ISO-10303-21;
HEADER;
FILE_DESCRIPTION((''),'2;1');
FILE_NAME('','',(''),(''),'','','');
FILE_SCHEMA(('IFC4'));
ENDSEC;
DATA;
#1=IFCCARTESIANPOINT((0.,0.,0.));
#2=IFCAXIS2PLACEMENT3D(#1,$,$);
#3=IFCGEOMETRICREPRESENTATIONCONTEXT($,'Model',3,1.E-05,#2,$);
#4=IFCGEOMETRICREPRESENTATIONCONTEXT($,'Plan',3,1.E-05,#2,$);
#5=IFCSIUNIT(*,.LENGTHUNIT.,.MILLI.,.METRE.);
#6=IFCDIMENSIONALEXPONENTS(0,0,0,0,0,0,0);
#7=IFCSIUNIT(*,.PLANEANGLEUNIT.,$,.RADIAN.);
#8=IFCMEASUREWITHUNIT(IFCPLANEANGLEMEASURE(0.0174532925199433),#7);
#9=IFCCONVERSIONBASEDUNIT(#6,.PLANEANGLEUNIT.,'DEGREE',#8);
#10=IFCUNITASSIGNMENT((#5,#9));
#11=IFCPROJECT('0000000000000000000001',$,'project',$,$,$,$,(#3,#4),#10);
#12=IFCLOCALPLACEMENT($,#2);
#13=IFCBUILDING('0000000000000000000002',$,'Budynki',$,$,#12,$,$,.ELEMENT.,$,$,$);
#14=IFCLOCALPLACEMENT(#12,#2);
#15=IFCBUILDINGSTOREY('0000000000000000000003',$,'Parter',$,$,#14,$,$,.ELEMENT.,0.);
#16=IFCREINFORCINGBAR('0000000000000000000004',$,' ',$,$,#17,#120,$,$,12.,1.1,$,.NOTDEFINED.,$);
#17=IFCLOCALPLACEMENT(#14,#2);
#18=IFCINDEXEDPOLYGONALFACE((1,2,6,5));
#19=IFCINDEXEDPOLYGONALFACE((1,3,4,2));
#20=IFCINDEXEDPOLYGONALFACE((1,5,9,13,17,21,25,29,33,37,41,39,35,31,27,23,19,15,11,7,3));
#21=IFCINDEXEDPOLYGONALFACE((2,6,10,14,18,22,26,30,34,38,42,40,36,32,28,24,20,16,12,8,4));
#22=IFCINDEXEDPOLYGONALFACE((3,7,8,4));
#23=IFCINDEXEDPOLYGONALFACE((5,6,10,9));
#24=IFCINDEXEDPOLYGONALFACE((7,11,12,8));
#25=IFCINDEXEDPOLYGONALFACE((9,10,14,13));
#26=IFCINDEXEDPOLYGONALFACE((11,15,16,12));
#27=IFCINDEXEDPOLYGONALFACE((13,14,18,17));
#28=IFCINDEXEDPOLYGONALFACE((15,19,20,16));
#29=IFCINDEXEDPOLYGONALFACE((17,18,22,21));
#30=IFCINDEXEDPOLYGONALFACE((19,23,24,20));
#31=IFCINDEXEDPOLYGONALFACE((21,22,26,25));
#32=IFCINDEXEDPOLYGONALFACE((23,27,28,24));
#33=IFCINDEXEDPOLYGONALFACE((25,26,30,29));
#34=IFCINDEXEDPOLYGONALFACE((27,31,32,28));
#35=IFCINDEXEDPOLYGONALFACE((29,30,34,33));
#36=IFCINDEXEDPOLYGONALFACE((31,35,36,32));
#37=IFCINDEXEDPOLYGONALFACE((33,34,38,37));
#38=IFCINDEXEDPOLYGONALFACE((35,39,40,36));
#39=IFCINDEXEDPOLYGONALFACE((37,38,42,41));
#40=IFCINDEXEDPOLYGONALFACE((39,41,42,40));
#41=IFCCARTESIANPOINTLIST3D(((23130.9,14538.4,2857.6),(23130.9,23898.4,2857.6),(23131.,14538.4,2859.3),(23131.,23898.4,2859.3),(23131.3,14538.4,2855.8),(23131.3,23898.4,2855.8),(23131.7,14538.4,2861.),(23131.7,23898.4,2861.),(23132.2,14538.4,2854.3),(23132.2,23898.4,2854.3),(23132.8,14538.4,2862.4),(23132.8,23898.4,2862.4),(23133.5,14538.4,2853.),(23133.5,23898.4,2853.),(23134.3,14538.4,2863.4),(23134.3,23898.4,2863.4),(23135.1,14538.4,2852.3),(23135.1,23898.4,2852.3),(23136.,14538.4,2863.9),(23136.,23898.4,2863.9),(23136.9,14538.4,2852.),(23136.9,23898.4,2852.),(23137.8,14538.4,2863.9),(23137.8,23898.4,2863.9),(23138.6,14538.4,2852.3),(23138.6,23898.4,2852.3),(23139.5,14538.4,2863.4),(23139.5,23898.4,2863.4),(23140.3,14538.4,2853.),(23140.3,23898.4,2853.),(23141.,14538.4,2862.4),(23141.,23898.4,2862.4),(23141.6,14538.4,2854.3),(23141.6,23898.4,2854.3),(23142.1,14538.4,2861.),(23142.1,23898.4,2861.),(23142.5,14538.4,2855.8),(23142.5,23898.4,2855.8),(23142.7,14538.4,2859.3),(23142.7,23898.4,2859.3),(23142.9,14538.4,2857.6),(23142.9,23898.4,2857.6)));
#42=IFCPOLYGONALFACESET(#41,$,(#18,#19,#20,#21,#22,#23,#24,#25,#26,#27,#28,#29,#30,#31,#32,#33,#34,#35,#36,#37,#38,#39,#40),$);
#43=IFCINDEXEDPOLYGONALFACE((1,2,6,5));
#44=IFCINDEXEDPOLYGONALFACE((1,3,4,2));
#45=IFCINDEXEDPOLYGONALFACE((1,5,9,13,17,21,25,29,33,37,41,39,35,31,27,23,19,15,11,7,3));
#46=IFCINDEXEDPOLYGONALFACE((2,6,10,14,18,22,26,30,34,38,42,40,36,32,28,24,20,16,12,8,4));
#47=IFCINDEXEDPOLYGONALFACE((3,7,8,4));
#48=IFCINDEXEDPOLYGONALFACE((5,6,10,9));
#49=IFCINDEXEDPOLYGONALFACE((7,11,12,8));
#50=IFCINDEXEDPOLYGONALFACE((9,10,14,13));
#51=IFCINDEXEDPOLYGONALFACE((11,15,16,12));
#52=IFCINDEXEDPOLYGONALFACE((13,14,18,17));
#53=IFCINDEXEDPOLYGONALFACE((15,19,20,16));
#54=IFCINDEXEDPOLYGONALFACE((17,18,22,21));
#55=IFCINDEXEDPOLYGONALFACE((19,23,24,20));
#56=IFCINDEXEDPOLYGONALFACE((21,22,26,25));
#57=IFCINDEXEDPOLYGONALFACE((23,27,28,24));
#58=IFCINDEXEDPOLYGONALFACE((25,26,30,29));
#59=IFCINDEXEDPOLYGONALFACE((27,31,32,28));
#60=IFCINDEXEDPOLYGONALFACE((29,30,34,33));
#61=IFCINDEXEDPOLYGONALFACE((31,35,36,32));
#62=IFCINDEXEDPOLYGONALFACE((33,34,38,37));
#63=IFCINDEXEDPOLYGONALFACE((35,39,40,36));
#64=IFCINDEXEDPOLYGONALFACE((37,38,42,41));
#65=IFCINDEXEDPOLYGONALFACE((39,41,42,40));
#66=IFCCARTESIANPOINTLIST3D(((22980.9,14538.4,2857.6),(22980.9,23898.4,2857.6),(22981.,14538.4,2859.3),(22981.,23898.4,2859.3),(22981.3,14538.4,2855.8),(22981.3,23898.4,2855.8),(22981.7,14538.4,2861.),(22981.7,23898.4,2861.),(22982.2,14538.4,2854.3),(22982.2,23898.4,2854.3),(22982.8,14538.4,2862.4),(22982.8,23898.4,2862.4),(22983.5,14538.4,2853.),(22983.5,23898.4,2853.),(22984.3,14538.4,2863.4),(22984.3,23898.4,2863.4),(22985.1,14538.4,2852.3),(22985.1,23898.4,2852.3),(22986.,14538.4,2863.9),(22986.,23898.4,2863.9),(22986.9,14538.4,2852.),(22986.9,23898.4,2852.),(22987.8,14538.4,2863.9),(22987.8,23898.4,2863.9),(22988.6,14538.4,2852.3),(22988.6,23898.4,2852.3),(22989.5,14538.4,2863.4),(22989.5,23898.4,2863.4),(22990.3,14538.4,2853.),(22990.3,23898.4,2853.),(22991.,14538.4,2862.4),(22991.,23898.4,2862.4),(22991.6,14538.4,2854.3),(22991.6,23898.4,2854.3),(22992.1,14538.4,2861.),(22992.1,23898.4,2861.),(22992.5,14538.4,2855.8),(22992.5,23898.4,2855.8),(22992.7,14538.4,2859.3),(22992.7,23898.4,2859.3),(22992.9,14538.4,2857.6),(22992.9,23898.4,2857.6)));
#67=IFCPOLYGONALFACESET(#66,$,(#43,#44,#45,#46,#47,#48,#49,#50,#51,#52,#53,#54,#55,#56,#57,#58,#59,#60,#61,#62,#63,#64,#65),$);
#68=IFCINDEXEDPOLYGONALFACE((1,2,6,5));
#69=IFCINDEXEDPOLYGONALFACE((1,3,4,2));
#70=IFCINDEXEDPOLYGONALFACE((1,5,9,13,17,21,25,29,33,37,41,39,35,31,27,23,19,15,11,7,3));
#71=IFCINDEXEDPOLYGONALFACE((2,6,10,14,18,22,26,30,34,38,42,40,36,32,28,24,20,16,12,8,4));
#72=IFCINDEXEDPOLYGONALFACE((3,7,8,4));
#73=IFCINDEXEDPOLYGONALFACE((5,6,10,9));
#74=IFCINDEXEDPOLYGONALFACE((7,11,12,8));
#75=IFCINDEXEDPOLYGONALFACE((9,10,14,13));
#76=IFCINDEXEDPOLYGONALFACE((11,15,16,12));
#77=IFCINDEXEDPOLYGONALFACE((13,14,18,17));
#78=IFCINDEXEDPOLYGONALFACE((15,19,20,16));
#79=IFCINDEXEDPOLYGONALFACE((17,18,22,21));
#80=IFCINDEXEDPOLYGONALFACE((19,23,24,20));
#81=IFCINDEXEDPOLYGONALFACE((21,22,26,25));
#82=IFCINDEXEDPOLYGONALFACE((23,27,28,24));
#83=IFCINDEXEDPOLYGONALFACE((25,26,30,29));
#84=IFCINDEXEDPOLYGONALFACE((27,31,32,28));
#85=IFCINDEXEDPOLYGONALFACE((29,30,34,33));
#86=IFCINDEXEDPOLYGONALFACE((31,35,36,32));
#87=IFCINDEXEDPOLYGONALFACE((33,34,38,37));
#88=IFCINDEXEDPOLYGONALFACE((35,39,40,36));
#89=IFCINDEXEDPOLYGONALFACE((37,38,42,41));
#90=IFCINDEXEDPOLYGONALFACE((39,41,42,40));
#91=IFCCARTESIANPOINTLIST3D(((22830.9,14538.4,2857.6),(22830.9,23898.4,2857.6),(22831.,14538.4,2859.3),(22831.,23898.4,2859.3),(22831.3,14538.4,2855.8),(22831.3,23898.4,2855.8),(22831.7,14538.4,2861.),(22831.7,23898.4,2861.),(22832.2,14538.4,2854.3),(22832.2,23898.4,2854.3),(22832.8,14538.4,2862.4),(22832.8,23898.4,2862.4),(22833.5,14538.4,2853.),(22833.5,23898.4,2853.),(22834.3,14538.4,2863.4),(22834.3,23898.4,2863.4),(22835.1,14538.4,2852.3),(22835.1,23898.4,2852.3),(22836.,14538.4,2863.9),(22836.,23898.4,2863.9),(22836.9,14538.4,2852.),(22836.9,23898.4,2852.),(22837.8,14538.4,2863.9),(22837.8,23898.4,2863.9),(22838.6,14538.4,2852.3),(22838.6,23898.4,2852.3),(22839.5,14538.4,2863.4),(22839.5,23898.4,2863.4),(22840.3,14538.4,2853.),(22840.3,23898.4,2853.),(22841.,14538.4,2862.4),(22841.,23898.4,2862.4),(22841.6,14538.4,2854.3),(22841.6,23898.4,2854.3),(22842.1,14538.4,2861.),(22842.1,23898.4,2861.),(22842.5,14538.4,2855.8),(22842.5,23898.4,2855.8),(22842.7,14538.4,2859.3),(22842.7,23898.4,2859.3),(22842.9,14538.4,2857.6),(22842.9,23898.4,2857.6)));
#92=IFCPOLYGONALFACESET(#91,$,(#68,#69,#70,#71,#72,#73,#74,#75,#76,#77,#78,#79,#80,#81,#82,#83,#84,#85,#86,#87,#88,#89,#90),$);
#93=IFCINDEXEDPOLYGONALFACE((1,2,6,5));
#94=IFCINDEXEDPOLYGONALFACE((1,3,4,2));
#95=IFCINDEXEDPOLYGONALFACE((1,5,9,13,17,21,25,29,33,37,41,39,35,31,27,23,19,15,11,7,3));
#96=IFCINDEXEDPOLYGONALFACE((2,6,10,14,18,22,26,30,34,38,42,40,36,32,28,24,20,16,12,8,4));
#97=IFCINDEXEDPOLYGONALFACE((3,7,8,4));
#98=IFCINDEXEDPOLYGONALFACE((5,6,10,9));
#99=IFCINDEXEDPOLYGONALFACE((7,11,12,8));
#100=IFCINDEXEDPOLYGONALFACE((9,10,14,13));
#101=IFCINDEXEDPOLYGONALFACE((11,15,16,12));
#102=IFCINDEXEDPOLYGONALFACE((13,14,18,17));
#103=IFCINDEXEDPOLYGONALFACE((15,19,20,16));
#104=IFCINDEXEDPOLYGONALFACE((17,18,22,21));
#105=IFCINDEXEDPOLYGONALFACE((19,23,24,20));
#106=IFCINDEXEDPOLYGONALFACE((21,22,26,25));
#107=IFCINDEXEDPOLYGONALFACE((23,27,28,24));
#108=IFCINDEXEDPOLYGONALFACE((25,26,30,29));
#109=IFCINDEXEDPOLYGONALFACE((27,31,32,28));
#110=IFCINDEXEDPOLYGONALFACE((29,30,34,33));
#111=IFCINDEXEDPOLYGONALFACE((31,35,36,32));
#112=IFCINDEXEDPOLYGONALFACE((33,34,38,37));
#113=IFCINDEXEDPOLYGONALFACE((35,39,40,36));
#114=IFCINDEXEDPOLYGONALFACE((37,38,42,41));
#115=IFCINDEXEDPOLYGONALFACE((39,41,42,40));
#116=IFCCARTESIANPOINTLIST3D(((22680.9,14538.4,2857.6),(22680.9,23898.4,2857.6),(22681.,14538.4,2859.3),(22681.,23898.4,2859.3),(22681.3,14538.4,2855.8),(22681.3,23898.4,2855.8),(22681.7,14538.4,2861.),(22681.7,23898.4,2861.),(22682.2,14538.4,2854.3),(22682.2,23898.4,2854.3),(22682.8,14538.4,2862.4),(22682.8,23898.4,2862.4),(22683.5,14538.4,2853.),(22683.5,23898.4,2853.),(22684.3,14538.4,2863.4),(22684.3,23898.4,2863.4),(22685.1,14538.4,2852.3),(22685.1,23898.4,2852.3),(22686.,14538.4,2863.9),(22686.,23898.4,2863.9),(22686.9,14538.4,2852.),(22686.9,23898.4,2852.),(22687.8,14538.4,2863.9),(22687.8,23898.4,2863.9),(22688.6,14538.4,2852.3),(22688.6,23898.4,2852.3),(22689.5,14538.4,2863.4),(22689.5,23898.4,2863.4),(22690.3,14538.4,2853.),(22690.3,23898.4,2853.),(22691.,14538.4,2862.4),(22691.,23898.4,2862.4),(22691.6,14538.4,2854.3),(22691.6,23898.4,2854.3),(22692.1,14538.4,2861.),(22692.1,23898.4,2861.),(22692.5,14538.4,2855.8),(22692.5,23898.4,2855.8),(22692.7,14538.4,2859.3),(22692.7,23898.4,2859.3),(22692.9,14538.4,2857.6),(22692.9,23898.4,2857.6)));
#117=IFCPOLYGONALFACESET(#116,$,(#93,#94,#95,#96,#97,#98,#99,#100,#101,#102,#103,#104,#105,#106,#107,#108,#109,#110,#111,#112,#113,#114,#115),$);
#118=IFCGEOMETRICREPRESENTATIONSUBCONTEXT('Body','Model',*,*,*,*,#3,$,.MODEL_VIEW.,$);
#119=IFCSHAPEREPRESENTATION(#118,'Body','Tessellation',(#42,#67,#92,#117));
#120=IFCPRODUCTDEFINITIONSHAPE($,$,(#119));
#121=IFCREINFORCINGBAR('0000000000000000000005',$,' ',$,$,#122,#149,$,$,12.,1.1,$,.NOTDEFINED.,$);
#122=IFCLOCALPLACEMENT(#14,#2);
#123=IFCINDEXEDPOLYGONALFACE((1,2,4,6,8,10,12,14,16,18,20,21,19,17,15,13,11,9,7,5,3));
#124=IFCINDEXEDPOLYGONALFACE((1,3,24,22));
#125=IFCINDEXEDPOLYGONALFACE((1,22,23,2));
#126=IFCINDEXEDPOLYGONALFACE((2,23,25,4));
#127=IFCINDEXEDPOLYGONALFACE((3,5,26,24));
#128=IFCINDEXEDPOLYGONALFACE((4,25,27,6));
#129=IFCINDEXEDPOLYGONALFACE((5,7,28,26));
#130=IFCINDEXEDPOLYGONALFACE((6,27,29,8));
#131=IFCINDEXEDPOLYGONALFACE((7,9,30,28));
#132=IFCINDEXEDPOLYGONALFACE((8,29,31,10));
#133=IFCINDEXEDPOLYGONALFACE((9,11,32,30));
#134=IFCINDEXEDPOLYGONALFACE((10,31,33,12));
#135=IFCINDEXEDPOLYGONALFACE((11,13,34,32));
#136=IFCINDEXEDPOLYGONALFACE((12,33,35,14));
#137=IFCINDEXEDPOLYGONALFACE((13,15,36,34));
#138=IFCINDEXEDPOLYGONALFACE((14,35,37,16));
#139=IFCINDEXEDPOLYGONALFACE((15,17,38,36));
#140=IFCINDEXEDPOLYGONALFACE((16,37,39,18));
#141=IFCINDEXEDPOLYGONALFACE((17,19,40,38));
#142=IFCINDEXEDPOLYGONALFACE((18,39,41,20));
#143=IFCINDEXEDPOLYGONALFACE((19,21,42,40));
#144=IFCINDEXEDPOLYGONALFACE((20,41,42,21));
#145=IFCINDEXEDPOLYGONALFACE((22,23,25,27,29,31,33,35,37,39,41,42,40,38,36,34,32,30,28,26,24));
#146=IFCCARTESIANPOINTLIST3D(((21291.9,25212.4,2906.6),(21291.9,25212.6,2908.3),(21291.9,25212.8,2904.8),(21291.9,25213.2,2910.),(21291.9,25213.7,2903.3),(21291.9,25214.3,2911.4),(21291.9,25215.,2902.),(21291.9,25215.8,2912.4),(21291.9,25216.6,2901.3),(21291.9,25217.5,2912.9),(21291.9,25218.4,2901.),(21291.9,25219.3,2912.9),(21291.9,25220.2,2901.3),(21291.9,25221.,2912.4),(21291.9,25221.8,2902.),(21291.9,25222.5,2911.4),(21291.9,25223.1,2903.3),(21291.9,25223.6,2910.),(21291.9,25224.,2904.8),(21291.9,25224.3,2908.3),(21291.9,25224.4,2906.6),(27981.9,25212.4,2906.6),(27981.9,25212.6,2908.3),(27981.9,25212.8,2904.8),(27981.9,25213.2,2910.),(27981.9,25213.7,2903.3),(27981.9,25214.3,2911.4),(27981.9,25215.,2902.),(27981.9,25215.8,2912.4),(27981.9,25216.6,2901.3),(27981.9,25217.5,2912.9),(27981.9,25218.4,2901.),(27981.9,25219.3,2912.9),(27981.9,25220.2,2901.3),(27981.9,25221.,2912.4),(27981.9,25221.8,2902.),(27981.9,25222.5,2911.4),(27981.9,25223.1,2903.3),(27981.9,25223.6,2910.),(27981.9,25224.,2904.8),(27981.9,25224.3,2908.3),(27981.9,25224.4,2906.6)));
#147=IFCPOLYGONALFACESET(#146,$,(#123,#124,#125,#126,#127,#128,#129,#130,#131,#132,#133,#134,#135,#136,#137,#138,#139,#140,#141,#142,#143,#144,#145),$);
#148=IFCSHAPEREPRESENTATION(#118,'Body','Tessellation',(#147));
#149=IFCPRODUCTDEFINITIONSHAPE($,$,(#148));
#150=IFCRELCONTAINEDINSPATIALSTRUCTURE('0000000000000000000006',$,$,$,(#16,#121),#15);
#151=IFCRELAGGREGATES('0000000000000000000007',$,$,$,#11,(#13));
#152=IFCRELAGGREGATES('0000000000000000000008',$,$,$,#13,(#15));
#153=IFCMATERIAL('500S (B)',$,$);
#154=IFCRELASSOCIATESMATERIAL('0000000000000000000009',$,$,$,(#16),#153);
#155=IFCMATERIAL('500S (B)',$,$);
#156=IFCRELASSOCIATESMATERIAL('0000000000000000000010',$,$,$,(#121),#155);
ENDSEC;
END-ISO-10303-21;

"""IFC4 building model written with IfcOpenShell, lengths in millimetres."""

from ifc_helpers import new_model, entity, si_unit, converted_unit, frame, origin, place, context, subcontext, project, spatial, material, element, save


model = new_model("IFC4")

# Units and contexts
model_context = context("Model", 3, precision=1e-05, world=origin())
plan_context = context("Plan", 3, precision=1e-05, world=origin())
body_context = subcontext(model_context, "Body", "Model", "MODEL_VIEW")
ifc_project = project(units=[si_unit("LENGTHUNIT", "METRE", prefix="MILLI"), converted_unit("PLANEANGLEUNIT", "DEGREE", entity("IfcPlaneAngleMeasure", 0.0174532925199433), si_unit("PLANEANGLEUNIT", "RADIAN"), dimensions=[0, 0, 0, 0, 0, 0, 0])], contexts=[model_context, plan_context])

# Building, storey
building_placement = place(None, origin())
building = spatial("IfcBuilding", under=ifc_project, at=building_placement, Name="Budynki", CompositionType="ELEMENT")
storey_placement = place(building_placement, origin())
storey = spatial("IfcBuildingStorey", under=building, at=storey_placement, Name="Parter", CompositionType="ELEMENT", Elevation=0.0)

# Reinforcing bars
ifc_material_1 = material(Name="500S (B)")
reinforcing_bar_1_placement = place(storey_placement, frame((23136.9, 23898.4, 2858.0)))
element("IfcReinforcingBar", 1, at=reinforcing_bar_1_placement, inside=storey, material=ifc_material_1, Name=" ", CrossSectionArea=1.1, NominalDiameter=12.0, PredefinedType="NOTDEFINED", context=body_context, shape_type="AdvancedSweptSolid", body=[
    entity("IfcSweptDiskSolid", entity("IfcPolyline", [entity("IfcCartesianPoint", [0.0, 0.0, 0.0]), entity("IfcCartesianPoint", [0.0, -9360.0, 0.0])]), 6.0, None, 0.0, 1.0),
    entity("IfcSweptDiskSolid", entity("IfcPolyline", [entity("IfcCartesianPoint", [-150.0, 0.0, 0.0]), entity("IfcCartesianPoint", [-150.0, -9360.0, 0.0])]), 6.0, None, 0.0, 1.0),
    entity("IfcSweptDiskSolid", entity("IfcPolyline", [entity("IfcCartesianPoint", [-300.0, 0.0, 0.0]), entity("IfcCartesianPoint", [-300.0, -9360.0, 0.0])]), 6.0, None, 0.0, 1.0),
    entity("IfcSweptDiskSolid", entity("IfcPolyline", [entity("IfcCartesianPoint", [-450.0, 0.0, 0.0]), entity("IfcCartesianPoint", [-450.0, -9360.0, 0.0])]), 6.0, None, 0.0, 1.0),
])
ifc_material_2 = material(Name="500S (B)")
reinforcing_bar_2_placement = place(storey_placement, frame((27981.9, 25218.4, 2907.0)))
element("IfcReinforcingBar", 2, at=reinforcing_bar_2_placement, inside=storey, material=ifc_material_2, Name=" ", CrossSectionArea=1.1, NominalDiameter=12.0, PredefinedType="NOTDEFINED", context=body_context, shape_type="AdvancedSweptSolid", body=[
    entity("IfcSweptDiskSolid", entity("IfcPolyline", [entity("IfcCartesianPoint", [0.0, 0.0, 0.0]), entity("IfcCartesianPoint", [-6690.0, 0.0, 0.0])]), 6.0, None, 0.0, 1.0),
])

save(model, "model.ifc")
